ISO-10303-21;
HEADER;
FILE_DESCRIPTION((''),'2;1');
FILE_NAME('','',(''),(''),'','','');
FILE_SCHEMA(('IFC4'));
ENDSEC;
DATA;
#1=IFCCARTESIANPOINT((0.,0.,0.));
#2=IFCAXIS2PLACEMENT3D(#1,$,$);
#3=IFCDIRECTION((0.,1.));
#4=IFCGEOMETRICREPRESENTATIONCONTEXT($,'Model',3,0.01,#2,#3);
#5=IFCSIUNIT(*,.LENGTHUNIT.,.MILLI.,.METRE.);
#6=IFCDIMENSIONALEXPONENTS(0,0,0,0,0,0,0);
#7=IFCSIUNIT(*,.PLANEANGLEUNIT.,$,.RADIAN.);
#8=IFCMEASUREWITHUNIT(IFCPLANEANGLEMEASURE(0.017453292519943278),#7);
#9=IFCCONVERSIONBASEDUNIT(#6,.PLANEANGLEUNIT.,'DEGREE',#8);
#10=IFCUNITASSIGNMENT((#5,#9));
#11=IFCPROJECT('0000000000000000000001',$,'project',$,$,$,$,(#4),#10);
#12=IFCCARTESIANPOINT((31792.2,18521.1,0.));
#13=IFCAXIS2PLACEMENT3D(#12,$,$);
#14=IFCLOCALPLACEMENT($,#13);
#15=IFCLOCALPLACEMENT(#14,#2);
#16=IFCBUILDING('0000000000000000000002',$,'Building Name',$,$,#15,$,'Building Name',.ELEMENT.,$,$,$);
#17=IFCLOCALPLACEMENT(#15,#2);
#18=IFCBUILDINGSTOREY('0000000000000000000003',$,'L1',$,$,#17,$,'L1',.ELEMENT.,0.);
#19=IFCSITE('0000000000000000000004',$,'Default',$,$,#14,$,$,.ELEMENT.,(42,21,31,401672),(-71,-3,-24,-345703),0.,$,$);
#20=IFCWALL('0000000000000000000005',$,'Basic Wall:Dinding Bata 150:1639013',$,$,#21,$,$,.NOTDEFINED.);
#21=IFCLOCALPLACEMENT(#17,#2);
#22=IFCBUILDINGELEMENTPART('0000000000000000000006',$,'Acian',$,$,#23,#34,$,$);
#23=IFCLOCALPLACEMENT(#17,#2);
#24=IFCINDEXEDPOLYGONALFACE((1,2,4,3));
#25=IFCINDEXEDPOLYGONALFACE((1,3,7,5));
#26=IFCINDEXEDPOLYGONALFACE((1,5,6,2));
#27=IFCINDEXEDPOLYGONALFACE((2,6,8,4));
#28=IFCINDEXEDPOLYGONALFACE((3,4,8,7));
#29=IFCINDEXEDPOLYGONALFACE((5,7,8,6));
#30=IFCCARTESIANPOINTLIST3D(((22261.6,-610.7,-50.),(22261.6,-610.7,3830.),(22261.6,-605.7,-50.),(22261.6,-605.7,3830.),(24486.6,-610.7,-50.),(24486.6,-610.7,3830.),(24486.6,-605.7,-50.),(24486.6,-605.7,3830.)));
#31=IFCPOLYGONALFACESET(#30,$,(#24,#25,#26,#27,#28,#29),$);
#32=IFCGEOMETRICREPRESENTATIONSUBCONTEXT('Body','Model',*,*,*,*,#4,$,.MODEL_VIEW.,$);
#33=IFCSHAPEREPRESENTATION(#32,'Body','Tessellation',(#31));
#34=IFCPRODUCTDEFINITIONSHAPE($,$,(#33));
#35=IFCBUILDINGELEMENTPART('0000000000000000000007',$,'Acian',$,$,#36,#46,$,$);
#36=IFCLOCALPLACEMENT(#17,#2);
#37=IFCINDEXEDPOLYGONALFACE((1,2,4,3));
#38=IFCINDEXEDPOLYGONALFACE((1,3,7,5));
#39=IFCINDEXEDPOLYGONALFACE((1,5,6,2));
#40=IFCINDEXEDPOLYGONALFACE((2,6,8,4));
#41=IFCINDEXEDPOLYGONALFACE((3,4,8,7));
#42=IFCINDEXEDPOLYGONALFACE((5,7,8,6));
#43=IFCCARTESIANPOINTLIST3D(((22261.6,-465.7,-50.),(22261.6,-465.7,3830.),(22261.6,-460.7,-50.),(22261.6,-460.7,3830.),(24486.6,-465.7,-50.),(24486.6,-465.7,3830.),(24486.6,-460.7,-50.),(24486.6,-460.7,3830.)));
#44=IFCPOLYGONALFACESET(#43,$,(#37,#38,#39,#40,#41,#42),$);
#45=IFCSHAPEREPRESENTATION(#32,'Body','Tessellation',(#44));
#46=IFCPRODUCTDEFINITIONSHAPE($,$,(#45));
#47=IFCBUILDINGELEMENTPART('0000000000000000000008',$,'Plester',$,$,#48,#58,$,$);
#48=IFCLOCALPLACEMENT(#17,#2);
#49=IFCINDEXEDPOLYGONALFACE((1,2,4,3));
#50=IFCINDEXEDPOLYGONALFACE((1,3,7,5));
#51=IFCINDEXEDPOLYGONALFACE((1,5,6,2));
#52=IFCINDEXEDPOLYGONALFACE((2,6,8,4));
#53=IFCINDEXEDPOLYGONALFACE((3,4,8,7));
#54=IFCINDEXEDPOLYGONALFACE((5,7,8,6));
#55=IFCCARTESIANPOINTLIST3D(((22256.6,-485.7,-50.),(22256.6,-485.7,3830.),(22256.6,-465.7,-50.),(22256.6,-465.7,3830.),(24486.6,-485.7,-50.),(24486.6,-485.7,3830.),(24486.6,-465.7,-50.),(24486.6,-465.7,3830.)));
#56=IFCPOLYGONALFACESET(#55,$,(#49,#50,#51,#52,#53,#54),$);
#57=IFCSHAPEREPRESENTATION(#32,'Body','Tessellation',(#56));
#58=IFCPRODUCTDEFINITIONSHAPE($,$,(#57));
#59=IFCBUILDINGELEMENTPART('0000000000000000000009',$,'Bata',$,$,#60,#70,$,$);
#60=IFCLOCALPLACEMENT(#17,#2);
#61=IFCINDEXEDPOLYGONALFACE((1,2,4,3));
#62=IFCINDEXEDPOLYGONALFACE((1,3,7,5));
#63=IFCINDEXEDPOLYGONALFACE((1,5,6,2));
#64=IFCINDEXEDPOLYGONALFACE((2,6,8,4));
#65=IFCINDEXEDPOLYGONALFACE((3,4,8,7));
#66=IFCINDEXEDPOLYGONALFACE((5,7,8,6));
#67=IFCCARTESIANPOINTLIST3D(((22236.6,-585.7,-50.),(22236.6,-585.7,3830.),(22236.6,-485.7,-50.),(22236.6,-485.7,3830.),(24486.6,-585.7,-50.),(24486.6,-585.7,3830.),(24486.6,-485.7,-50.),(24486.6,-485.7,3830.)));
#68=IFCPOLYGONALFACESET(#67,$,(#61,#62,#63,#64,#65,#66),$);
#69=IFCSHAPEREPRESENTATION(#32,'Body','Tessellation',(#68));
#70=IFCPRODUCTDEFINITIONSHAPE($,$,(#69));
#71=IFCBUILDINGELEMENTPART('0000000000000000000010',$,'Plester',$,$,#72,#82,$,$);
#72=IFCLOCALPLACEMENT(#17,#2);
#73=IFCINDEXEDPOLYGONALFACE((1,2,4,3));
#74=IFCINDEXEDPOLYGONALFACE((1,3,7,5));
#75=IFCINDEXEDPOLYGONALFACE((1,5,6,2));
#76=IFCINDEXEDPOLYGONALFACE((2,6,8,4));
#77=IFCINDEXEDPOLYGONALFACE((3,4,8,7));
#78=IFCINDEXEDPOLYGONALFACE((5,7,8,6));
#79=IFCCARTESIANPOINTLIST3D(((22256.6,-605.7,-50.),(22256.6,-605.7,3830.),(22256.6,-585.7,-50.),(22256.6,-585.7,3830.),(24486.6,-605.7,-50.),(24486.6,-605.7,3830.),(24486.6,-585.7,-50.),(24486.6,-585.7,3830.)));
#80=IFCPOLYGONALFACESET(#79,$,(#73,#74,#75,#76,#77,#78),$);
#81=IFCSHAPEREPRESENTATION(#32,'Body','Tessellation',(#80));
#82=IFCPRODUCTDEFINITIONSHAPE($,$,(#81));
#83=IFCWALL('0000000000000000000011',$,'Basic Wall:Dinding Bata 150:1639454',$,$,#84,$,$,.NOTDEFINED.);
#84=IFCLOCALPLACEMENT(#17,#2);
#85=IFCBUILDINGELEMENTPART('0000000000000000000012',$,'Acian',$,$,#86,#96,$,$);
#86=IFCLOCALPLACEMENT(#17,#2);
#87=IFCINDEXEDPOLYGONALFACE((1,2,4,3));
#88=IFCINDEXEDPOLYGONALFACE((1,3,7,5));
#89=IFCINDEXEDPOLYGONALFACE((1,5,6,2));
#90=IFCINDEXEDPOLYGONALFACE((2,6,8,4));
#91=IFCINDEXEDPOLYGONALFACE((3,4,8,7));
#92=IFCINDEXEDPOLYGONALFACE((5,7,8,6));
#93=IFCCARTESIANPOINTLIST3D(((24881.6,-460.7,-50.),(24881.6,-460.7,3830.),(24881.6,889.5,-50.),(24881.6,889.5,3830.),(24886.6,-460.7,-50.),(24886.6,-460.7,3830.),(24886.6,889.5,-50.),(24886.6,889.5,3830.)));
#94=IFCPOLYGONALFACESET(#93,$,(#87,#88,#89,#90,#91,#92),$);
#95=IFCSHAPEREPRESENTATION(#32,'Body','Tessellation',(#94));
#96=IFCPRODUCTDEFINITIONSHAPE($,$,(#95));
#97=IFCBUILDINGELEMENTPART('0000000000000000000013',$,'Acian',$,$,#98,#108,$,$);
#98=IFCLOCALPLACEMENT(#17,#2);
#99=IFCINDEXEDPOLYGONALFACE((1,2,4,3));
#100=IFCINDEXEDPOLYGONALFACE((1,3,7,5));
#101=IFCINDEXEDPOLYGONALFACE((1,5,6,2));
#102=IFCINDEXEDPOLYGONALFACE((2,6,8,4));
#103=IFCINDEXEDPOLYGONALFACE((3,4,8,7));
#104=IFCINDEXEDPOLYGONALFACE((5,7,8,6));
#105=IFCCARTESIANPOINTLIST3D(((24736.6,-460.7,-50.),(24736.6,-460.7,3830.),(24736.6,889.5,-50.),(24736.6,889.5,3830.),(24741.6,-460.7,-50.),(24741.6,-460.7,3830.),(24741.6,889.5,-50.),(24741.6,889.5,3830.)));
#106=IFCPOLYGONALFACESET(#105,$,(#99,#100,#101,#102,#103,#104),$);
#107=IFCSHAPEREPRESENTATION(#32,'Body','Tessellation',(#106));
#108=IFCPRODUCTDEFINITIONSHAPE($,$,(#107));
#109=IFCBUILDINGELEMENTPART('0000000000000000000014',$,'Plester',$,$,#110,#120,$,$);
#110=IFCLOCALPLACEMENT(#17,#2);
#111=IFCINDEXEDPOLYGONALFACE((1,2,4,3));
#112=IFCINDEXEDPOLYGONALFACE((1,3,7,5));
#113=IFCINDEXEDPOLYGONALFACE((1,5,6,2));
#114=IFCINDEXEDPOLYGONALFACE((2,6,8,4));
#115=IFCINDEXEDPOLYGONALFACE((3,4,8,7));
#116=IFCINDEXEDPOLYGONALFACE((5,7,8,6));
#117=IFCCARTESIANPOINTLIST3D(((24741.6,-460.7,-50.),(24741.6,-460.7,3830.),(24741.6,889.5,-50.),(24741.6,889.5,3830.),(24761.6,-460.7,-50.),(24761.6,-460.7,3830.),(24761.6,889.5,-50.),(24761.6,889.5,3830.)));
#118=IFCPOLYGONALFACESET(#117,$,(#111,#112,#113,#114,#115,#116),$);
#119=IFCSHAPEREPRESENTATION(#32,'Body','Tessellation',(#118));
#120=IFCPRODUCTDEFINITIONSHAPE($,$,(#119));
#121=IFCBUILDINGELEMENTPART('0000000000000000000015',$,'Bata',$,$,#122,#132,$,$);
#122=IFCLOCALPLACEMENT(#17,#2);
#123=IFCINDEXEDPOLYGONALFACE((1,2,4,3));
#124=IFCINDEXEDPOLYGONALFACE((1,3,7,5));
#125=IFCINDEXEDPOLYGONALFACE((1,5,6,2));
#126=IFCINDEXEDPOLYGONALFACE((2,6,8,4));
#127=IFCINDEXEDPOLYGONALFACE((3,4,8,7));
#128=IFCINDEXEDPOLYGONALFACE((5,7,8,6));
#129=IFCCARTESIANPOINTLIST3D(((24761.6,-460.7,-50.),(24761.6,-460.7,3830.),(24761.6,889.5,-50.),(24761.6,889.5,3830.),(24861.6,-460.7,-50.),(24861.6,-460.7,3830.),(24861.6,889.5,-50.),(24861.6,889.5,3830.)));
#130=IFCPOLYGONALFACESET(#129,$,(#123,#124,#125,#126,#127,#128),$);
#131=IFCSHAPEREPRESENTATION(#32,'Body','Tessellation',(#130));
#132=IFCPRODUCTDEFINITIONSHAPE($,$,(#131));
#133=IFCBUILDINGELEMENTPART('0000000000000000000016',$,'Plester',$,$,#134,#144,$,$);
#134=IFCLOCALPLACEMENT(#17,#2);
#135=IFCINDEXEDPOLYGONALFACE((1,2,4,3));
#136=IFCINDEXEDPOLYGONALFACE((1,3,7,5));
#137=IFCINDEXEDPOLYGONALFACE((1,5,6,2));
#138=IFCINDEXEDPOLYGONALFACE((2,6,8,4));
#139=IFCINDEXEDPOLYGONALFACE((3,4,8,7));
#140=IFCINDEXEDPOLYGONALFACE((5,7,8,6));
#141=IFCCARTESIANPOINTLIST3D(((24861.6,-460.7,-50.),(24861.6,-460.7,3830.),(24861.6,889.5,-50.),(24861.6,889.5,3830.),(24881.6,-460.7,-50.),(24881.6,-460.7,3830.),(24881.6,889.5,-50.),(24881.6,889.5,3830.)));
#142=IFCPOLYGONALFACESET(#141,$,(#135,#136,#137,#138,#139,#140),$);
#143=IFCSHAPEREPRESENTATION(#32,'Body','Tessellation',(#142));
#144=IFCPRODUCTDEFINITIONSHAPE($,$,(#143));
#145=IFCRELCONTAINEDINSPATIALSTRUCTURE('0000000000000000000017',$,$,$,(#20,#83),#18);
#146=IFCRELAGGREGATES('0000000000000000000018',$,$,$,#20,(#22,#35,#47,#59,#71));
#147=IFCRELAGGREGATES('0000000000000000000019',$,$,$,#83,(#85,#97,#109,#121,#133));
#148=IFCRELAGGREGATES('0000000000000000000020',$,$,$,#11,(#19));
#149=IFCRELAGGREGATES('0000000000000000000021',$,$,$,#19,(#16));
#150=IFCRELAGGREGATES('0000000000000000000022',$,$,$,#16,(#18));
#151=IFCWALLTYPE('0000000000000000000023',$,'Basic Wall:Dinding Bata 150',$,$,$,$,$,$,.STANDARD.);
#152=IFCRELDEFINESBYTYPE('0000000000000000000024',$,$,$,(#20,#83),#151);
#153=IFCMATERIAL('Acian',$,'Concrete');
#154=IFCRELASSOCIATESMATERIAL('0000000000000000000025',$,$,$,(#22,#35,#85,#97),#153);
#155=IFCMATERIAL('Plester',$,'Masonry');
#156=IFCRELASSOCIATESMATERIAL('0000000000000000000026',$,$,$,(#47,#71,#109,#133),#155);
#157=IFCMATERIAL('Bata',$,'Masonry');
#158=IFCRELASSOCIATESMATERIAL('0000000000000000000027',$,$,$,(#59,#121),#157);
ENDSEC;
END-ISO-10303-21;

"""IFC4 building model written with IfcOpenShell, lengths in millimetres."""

from ifc_helpers import new_model, entity, si_unit, converted_unit, direction, frame, origin, place, context, subcontext, project, spatial, indexed_curve, outline, extrude, material, type_object, element, aggregate, save


model = new_model("IFC4")

# Units and contexts
model_context = context("Model", 3, precision=0.01, world=origin(), true_north=direction((0.0, 1.0)))
body_context = subcontext(model_context, "Body", "Model", "MODEL_VIEW")
ifc_project = project(units=[si_unit("LENGTHUNIT", "METRE", prefix="MILLI"), converted_unit("PLANEANGLEUNIT", "DEGREE", entity("IfcPlaneAngleMeasure", 0.017453292519943278), si_unit("PLANEANGLEUNIT", "RADIAN"), dimensions=[0, 0, 0, 0, 0, 0, 0])], contexts=[model_context])

# Site, building, storey
site_placement = place(None, frame((31792.2, 18521.1, 0.0)))
site = spatial("IfcSite", under=ifc_project, at=site_placement, Name="Default", CompositionType="ELEMENT", RefLatitude=(42, 21, 31, 401672), RefLongitude=(-71, -3, -24, -345703), RefElevation=0.0)
building_placement = place(site_placement, origin())
building = spatial("IfcBuilding", under=site, at=building_placement, Name="Building Name", LongName="Building Name", CompositionType="ELEMENT")
storey_placement = place(building_placement, origin())
storey = spatial("IfcBuildingStorey", under=building, at=storey_placement, Name="L1", LongName="L1", CompositionType="ELEMENT", Elevation=0.0)

# Walls, building element parts
wall_type = type_object("IfcWallType", Name="Basic Wall:Dinding Bata 150", PredefinedType="STANDARD")
ifc_material_1 = material(Name="Plester", Category="Masonry")
ifc_material_2 = material(Name="Bata", Category="Masonry")
ifc_material_3 = material(Name="Acian", Category="Concrete")
wall_1_placement = place(storey_placement, frame((22261.6, -535.7, -50.0)))
wall_1 = element("IfcWall", 1, at=wall_1_placement, inside=storey, type_object=wall_type, Name="Basic Wall:Dinding Bata 150:1639013", PredefinedType="NOTDEFINED")
building_element_part_1_placement = place(wall_1_placement, origin())
building_element_part_1 = element("IfcBuildingElementPart", 2, at=building_element_part_1_placement, material=ifc_material_3, Name="Acian", context=body_context, shape_type="SweptSolid", body=[
    extrude(outline(indexed_curve([(-2.5, -1112.5), (2.5, -1112.5), (2.5, 1112.5), (-2.5, 1112.5), (-2.5, -1112.5)], self_intersect=False)), frame((1112.5, -72.5, 0.0), z_axis=(0.0, 0.0, 1.0), x_axis=(0.0, -1.0, 0.0)), (0.0, 0.0, 1.0), 3880.0),
])
building_element_part_2_placement = place(wall_1_placement, origin())
building_element_part_2 = element("IfcBuildingElementPart", 3, at=building_element_part_2_placement, material=ifc_material_3, Name="Acian", context=body_context, shape_type="SweptSolid", body=[
    extrude(outline(indexed_curve([(-2.5, -1112.5), (2.5, -1112.5), (2.5, 1112.5), (-2.5, 1112.5), (-2.5, -1112.5)], self_intersect=False)), frame((1112.5, 72.5, 0.0), z_axis=(0.0, 0.0, 1.0), x_axis=(0.0, -1.0, 0.0)), (0.0, 0.0, 1.0), 3880.0),
])
building_element_part_3_placement = place(wall_1_placement, origin())
building_element_part_3 = element("IfcBuildingElementPart", 4, at=building_element_part_3_placement, material=ifc_material_1, Name="Plester", context=body_context, shape_type="SweptSolid", body=[
    extrude(outline(indexed_curve([(-10.0, -1115.0), (10.0, -1115.0), (10.0, 1115.0), (-10.0, 1115.0), (-10.0, -1115.0)], self_intersect=False)), frame((1110.0, 60.0, 0.0), z_axis=(0.0, 0.0, 1.0), x_axis=(0.0, -1.0, 0.0)), (0.0, 0.0, 1.0), 3880.0),
])
building_element_part_4_placement = place(wall_1_placement, origin())
building_element_part_4 = element("IfcBuildingElementPart", 5, at=building_element_part_4_placement, material=ifc_material_2, Name="Bata", context=body_context, shape_type="SweptSolid", body=[
    extrude(outline(indexed_curve([(-50.0, -1125.0), (50.0, -1125.0), (50.0, 1125.0), (-50.0, 1125.0), (-50.0, -1125.0)], self_intersect=False)), frame((1100.0, 0.0, 0.0), z_axis=(0.0, 0.0, 1.0), x_axis=(0.0, -1.0, 0.0)), (0.0, 0.0, 1.0), 3880.0),
])
building_element_part_5_placement = place(wall_1_placement, origin())
building_element_part_5 = element("IfcBuildingElementPart", 6, at=building_element_part_5_placement, material=ifc_material_1, Name="Plester", context=body_context, shape_type="SweptSolid", body=[
    extrude(outline(indexed_curve([(-10.0, -1115.0), (10.0, -1115.0), (10.0, 1115.0), (-10.0, 1115.0), (-10.0, -1115.0)], self_intersect=False)), frame((1110.0, -60.0, 0.0), z_axis=(0.0, 0.0, 1.0), x_axis=(0.0, -1.0, 0.0)), (0.0, 0.0, 1.0), 3880.0),
])
aggregate(wall_1, [building_element_part_1, building_element_part_2, building_element_part_3, building_element_part_4, building_element_part_5])
wall_2_placement = place(storey_placement, frame((24811.6, -460.7, -50.0), z_axis=(0.0, 0.0, 1.0), x_axis=(0.0, 1.0, 0.0)))
wall_2 = element("IfcWall", 7, at=wall_2_placement, inside=storey, type_object=wall_type, Name="Basic Wall:Dinding Bata 150:1639454", PredefinedType="NOTDEFINED")
building_element_part_6_placement = place(wall_2_placement, origin())
building_element_part_6 = element("IfcBuildingElementPart", 8, at=building_element_part_6_placement, material=ifc_material_3, Name="Acian", context=body_context, shape_type="SweptSolid", body=[
    extrude(outline(indexed_curve([(-675.1, -2.5), (675.1, -2.5), (675.1, 2.5), (-675.1, 2.5), (-675.1, -2.5)], self_intersect=False)), frame((675.1, -72.5, 0.0), z_axis=(0.0, 0.0, 1.0), x_axis=(-1.0, 0.0, 0.0)), (0.0, 0.0, 1.0), 3880.0),
])
building_element_part_7_placement = place(wall_2_placement, origin())
building_element_part_7 = element("IfcBuildingElementPart", 9, at=building_element_part_7_placement, material=ifc_material_3, Name="Acian", context=body_context, shape_type="SweptSolid", body=[
    extrude(outline(indexed_curve([(-675.1, -2.5), (675.1, -2.5), (675.1, 2.5), (-675.1, 2.5), (-675.1, -2.5)], self_intersect=False)), frame((675.1, 72.5, 0.0), z_axis=(0.0, 0.0, 1.0), x_axis=(-1.0, 0.0, 0.0)), (0.0, 0.0, 1.0), 3880.0),
])
building_element_part_8_placement = place(wall_2_placement, origin())
building_element_part_8 = element("IfcBuildingElementPart", 10, at=building_element_part_8_placement, material=ifc_material_1, Name="Plester", context=body_context, shape_type="SweptSolid", body=[
    extrude(outline(indexed_curve([(-675.1, -10.0), (675.1, -10.0), (675.1, 10.0), (-675.1, 10.0), (-675.1, -10.0)], self_intersect=False)), frame((675.1, 60.0, 0.0), z_axis=(0.0, 0.0, 1.0), x_axis=(-1.0, 0.0, 0.0)), (0.0, 0.0, 1.0), 3880.0),
])
building_element_part_9_placement = place(wall_2_placement, origin())
building_element_part_9 = element("IfcBuildingElementPart", 11, at=building_element_part_9_placement, material=ifc_material_2, Name="Bata", context=body_context, shape_type="SweptSolid", body=[
    extrude(outline(indexed_curve([(-675.1, -50.0), (675.1, -50.0), (675.1, 50.0), (-675.1, 50.0), (-675.1, -50.0)], self_intersect=False)), frame((675.1, 0.0, 0.0), z_axis=(0.0, 0.0, 1.0), x_axis=(-1.0, 0.0, 0.0)), (0.0, 0.0, 1.0), 3880.0),
])
building_element_part_10_placement = place(wall_2_placement, origin())
building_element_part_10 = element("IfcBuildingElementPart", 12, at=building_element_part_10_placement, material=ifc_material_1, Name="Plester", context=body_context, shape_type="SweptSolid", body=[
    extrude(outline(indexed_curve([(-675.1, -10.0), (675.1, -10.0), (675.1, 10.0), (-675.1, 10.0), (-675.1, -10.0)], self_intersect=False)), frame((675.1, -60.0, 0.0), z_axis=(0.0, 0.0, 1.0), x_axis=(-1.0, 0.0, 0.0)), (0.0, 0.0, 1.0), 3880.0),
])
aggregate(wall_2, [building_element_part_6, building_element_part_7, building_element_part_8, building_element_part_9, building_element_part_10])

save(model, "model.ifc")
